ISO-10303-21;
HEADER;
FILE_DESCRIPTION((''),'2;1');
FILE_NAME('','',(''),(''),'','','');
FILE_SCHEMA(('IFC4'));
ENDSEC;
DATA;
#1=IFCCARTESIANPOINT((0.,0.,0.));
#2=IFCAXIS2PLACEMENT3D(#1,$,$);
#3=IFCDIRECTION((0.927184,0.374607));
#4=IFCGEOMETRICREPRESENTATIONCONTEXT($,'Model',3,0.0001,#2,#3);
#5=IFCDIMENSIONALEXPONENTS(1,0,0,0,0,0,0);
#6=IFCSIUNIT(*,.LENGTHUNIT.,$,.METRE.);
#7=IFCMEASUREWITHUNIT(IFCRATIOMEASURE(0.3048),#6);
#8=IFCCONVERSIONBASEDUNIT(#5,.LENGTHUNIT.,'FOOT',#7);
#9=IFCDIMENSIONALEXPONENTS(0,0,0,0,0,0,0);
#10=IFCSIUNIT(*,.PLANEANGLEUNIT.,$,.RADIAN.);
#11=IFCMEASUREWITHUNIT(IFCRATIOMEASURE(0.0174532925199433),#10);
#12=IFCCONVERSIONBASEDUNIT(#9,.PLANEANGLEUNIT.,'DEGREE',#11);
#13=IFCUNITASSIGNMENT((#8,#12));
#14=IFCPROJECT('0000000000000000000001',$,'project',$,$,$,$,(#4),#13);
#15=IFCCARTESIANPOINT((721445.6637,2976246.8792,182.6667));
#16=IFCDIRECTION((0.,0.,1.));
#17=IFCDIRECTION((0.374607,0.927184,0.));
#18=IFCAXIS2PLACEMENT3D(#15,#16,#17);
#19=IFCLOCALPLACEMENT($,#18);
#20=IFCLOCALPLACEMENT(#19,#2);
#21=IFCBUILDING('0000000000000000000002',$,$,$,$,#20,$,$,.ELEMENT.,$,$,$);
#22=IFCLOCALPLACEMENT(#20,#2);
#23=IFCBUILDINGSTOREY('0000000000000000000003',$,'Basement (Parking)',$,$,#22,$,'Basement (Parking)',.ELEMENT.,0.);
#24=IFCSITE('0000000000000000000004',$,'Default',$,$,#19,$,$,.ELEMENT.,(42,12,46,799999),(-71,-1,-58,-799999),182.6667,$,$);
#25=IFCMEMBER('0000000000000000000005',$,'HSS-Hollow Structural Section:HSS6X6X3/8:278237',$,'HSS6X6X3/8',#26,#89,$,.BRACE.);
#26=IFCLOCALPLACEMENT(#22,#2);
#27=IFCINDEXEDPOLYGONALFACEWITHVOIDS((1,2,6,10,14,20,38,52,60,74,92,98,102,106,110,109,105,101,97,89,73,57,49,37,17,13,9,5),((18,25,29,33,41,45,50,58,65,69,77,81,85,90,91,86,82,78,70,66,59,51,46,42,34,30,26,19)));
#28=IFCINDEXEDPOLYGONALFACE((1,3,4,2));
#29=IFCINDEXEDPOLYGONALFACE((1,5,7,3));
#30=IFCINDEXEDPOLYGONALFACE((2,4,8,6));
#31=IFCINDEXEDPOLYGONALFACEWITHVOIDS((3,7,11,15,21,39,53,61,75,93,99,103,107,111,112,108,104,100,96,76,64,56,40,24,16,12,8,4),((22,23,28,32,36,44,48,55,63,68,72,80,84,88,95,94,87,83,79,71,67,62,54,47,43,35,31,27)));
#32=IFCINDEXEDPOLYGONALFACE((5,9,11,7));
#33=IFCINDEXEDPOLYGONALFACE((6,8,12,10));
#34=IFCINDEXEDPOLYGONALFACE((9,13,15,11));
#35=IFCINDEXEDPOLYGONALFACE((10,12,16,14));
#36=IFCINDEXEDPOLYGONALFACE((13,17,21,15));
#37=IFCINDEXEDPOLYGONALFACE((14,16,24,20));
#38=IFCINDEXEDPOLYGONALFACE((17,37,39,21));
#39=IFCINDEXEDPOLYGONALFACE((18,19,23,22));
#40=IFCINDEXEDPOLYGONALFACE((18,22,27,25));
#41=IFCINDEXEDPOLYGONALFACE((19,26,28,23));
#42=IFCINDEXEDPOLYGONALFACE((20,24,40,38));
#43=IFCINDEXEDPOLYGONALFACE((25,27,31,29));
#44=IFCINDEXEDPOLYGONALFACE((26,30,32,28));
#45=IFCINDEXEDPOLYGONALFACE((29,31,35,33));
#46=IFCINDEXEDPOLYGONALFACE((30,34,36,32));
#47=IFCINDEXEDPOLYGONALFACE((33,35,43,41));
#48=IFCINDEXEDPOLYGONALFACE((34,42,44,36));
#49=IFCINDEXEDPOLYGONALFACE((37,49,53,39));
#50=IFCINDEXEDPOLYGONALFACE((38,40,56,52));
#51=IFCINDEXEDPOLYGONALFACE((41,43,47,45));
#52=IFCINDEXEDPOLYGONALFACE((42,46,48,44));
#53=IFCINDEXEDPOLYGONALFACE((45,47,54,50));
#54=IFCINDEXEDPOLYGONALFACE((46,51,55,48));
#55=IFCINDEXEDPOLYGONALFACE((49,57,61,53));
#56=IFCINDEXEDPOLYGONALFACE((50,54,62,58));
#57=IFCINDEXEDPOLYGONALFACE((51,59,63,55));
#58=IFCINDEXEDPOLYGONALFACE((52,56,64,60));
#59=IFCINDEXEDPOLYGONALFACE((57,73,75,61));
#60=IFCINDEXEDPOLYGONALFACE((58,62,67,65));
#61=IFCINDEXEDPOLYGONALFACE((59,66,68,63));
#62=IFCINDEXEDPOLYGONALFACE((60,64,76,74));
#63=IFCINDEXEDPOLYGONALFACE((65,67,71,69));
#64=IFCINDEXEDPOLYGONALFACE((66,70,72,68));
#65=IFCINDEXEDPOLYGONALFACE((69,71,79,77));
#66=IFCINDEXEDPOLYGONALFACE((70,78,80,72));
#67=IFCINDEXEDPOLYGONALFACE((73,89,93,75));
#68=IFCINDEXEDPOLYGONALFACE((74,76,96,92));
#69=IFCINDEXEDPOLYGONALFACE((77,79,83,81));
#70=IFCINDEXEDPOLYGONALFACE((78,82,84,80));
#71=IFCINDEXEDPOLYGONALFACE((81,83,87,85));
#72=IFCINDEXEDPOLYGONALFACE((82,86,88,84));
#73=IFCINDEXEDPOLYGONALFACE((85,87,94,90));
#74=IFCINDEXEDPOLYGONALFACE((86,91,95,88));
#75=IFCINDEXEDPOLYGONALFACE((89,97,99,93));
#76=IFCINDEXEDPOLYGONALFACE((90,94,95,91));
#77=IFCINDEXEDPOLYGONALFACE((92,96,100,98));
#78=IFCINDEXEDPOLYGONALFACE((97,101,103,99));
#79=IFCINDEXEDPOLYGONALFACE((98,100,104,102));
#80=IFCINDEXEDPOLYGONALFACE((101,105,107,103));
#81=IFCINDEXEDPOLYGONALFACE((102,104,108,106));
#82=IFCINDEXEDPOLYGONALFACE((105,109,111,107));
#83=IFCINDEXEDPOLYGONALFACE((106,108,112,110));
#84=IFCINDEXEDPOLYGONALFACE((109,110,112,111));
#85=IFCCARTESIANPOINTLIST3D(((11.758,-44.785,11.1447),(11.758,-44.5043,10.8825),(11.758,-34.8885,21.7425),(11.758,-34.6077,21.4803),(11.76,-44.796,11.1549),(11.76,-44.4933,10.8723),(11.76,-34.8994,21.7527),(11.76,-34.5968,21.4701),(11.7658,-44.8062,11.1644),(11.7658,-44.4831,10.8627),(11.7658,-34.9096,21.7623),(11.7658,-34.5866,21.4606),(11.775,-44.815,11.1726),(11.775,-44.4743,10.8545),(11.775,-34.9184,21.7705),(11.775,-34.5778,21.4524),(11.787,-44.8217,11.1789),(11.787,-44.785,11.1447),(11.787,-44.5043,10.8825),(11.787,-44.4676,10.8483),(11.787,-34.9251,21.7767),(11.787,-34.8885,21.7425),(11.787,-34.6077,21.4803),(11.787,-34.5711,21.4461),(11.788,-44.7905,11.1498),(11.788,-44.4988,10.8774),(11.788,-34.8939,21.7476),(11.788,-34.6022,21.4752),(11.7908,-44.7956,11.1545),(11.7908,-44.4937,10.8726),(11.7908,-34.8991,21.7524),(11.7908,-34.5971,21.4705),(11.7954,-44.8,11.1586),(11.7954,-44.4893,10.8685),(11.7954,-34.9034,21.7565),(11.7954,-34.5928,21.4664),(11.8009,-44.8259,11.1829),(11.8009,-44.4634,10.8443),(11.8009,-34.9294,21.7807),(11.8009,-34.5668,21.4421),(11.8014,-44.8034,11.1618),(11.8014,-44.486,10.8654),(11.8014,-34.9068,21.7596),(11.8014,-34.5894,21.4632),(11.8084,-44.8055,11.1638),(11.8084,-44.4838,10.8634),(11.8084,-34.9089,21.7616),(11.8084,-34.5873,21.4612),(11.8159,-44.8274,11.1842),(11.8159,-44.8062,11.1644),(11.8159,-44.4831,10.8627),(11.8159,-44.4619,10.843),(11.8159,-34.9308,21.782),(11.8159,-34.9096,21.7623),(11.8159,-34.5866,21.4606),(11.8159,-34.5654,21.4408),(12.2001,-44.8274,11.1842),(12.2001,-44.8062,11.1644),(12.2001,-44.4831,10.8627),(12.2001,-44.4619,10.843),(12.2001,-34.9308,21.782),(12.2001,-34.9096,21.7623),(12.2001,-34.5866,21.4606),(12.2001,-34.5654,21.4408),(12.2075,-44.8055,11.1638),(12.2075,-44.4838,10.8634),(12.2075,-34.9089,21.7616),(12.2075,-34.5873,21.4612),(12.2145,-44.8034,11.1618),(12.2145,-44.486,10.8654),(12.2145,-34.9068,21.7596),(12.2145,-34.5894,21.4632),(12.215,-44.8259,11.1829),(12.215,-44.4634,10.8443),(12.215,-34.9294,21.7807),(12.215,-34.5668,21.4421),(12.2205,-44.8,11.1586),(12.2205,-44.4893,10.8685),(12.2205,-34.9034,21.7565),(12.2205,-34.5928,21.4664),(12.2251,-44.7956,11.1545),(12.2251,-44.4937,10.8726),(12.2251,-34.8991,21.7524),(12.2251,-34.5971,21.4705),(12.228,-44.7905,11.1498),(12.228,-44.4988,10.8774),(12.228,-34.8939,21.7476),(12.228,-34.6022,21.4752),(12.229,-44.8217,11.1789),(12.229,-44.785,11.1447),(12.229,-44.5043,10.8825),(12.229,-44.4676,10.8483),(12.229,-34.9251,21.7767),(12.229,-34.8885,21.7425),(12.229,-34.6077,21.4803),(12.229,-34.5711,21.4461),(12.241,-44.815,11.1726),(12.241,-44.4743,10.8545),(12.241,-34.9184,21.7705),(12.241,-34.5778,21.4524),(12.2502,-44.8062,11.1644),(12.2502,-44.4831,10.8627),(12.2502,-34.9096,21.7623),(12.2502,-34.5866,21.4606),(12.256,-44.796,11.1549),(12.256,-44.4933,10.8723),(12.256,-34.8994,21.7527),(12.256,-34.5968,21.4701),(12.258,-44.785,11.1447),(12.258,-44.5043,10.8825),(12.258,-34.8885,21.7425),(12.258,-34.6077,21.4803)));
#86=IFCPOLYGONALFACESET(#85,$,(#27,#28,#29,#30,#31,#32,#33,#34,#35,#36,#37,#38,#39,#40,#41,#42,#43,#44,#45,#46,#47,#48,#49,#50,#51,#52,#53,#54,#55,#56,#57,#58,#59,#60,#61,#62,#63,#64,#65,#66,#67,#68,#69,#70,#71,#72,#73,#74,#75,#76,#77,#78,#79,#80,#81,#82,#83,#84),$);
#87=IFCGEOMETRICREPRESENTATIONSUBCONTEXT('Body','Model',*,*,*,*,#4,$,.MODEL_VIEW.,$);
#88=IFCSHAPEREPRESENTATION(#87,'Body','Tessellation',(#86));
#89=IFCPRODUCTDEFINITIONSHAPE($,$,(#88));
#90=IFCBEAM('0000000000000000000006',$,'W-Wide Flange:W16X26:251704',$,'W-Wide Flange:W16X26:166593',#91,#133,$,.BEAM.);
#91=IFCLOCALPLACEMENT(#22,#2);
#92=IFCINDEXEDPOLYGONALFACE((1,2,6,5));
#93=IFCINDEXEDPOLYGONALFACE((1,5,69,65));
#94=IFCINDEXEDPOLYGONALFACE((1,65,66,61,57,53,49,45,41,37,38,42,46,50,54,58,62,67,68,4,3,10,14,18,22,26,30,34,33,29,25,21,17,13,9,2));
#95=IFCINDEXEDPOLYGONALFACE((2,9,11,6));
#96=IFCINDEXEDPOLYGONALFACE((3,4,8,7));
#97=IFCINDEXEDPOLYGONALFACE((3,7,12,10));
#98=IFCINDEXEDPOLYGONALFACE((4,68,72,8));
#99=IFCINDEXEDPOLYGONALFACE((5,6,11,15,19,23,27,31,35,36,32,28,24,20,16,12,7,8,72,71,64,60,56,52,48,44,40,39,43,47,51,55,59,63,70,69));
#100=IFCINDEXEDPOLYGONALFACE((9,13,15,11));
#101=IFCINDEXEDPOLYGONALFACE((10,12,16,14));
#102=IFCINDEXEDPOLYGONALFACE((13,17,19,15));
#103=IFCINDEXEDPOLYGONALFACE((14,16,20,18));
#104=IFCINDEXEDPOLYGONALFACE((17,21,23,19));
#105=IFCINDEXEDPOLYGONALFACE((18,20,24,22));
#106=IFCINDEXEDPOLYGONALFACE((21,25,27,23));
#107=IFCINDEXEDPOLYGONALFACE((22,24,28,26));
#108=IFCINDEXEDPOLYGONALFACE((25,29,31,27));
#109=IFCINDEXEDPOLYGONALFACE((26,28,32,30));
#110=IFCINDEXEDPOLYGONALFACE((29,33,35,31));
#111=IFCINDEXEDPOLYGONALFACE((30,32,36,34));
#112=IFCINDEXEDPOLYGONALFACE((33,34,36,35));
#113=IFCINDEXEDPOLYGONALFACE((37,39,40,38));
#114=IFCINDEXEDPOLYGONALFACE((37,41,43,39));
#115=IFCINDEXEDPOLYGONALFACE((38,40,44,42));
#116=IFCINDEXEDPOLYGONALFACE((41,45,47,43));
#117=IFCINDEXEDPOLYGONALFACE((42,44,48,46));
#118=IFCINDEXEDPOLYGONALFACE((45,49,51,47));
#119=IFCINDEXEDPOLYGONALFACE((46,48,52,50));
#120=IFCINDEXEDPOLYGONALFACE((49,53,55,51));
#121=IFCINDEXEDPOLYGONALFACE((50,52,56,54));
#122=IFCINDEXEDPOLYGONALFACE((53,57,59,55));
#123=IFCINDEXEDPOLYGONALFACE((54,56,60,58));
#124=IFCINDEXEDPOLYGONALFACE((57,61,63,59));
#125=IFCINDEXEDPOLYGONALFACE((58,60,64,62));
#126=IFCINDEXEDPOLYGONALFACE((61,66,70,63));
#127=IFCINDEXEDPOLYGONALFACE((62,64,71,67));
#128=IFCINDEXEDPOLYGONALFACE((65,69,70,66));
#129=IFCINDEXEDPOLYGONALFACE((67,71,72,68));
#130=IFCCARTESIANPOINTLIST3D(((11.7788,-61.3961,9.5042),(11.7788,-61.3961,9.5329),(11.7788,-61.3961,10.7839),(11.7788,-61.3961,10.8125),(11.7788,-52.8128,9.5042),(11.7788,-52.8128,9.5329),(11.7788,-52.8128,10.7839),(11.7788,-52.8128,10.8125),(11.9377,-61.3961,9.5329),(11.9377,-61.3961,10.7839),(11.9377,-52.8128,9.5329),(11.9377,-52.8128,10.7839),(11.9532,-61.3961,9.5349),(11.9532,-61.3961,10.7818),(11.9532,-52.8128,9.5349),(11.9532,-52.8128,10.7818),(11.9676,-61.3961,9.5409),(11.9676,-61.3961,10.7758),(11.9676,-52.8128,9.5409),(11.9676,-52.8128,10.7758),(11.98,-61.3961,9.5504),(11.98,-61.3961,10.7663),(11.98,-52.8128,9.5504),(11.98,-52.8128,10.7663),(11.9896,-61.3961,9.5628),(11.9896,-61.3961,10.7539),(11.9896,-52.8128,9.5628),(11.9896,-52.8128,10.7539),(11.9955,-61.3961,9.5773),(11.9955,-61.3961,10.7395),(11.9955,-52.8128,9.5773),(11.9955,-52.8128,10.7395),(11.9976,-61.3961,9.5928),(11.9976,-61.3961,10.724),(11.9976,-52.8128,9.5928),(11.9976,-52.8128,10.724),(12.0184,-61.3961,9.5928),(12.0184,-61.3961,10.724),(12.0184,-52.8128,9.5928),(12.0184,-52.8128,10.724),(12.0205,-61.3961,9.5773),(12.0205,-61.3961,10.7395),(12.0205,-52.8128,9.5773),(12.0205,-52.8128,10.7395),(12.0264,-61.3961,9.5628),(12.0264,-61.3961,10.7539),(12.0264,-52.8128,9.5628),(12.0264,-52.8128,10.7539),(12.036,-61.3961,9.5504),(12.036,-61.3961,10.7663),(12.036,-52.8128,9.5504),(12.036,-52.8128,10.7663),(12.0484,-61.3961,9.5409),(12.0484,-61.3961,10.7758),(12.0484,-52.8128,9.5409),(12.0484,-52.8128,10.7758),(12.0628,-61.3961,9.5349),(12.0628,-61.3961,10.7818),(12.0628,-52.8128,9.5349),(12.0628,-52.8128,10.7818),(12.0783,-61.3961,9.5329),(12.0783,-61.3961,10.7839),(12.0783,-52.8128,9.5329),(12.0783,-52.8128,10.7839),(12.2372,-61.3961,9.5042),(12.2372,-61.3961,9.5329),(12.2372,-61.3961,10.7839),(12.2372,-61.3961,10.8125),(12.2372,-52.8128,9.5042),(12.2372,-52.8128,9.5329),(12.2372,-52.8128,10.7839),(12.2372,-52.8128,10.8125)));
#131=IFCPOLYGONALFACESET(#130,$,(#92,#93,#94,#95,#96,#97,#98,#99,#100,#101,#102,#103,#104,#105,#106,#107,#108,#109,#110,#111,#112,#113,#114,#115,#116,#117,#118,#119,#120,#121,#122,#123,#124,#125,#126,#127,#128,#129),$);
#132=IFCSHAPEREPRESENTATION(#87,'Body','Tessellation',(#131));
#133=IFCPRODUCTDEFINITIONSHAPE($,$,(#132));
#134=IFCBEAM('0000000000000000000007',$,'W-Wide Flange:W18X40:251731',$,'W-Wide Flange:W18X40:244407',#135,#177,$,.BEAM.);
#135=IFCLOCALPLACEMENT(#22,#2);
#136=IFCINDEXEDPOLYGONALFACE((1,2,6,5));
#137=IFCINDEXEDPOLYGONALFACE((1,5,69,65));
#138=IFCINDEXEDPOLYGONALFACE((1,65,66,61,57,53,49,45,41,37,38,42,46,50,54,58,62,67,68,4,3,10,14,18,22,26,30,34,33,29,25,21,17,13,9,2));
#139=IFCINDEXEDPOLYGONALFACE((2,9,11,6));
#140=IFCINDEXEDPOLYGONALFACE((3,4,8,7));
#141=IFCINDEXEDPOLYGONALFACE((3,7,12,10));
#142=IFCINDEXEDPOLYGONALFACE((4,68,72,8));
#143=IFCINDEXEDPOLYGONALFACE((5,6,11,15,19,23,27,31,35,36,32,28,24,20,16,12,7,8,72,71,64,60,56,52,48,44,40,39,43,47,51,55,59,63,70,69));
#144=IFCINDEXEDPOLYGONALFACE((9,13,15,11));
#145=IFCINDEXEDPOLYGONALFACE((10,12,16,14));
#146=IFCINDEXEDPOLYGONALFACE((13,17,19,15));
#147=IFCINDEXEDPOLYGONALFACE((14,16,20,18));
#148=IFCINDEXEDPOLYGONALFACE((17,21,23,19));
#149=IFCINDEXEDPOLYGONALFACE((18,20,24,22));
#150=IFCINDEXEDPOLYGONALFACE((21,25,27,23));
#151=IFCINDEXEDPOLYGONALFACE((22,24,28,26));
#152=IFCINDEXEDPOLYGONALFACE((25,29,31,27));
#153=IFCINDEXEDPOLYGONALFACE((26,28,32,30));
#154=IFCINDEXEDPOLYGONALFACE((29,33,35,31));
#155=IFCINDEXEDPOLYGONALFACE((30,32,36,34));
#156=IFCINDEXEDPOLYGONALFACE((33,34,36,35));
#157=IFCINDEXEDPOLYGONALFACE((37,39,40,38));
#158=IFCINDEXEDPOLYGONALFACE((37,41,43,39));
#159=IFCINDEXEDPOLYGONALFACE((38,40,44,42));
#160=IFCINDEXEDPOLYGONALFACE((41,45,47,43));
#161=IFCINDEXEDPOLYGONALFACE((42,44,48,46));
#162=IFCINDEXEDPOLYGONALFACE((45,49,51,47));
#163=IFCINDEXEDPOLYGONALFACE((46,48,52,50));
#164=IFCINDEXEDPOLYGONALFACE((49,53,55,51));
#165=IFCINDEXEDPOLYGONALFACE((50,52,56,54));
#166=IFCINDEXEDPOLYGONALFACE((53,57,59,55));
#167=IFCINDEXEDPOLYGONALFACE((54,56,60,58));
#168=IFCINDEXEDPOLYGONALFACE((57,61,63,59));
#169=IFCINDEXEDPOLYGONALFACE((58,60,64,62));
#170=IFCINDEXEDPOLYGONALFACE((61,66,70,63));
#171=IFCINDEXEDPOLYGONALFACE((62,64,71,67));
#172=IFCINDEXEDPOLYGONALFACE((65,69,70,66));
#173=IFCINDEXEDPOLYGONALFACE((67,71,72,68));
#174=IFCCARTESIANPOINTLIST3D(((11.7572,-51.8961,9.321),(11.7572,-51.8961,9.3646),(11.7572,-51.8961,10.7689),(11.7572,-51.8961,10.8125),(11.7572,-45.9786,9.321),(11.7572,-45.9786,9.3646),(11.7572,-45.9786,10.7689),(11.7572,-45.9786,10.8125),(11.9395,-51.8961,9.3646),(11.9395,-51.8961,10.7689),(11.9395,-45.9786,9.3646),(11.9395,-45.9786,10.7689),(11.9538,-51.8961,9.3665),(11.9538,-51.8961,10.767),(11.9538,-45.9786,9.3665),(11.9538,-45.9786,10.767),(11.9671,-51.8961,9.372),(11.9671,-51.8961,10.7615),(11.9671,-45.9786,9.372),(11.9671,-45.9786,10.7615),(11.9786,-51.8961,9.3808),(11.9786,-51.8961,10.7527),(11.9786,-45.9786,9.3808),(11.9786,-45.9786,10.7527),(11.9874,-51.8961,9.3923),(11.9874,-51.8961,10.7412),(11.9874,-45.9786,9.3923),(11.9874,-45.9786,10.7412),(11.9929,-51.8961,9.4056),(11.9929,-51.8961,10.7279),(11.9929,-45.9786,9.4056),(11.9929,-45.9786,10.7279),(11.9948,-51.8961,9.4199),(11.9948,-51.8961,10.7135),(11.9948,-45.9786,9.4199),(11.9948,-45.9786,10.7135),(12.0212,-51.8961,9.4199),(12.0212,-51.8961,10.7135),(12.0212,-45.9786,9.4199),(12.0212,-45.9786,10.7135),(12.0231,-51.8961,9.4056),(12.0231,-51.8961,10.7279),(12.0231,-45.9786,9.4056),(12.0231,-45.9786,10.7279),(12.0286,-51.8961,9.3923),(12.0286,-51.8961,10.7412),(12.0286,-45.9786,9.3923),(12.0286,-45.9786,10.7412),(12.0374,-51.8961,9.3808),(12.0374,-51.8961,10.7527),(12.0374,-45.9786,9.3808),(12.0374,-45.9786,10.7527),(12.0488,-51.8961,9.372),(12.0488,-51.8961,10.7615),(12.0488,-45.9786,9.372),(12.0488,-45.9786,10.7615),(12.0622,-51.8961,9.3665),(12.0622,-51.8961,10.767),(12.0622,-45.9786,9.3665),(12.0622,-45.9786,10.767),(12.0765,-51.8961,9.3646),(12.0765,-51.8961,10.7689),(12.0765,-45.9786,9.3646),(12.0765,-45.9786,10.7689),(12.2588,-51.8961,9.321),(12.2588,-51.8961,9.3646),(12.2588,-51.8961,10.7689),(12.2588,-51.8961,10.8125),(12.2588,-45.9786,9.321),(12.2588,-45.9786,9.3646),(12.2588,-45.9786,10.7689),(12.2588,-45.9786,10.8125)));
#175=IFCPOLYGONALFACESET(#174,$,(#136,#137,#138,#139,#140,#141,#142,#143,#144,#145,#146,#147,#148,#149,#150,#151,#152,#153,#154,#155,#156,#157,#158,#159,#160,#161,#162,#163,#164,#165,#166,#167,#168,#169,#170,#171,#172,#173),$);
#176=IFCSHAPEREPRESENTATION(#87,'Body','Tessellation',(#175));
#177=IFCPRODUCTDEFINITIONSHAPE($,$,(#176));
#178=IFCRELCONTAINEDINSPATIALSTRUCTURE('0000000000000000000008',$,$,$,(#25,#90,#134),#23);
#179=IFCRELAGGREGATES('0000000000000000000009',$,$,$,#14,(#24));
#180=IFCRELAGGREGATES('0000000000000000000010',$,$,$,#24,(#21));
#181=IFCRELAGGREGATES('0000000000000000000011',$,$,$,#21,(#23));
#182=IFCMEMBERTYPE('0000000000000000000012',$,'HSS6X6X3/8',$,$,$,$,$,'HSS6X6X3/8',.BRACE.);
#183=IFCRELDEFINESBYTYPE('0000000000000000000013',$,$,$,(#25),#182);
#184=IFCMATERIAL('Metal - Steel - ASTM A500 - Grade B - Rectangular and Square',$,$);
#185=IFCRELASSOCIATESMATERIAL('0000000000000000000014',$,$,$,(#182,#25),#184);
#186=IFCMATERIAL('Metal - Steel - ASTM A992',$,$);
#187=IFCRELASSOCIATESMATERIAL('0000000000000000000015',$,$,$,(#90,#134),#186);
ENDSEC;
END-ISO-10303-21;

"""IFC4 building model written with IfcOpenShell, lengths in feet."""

from ifc_helpers import new_model, entity, si_unit, converted_unit, direction, frame, frame_2d, origin, place, context, subcontext, project, spatial, polyline, circle_curve, parameter, trimmed, segment, composite_curve, i_section, outline, extrude, source, transform, mapped, material, type_object, type_shapes, element, save


model = new_model("IFC4")

# Units and contexts
model_context = context("Model", 3, precision=0.0001, world=origin(), true_north=direction((0.927184, 0.374607)))
body_context = subcontext(model_context, "Body", "Model", "MODEL_VIEW")
ifc_project = project(units=[converted_unit("LENGTHUNIT", "FOOT", entity("IfcRatioMeasure", 0.3048), si_unit("LENGTHUNIT", "METRE"), dimensions=[1, 0, 0, 0, 0, 0, 0]), converted_unit("PLANEANGLEUNIT", "DEGREE", entity("IfcRatioMeasure", 0.0174532925199433), si_unit("PLANEANGLEUNIT", "RADIAN"), dimensions=[0, 0, 0, 0, 0, 0, 0])], contexts=[model_context])

# Site, building, storey
site_placement = place(None, frame((721445.6637, 2976246.8792, 182.6667), z_axis=(0.0, 0.0, 1.0), x_axis=(0.374607, 0.927184, 0.0)))
site = spatial("IfcSite", under=ifc_project, at=site_placement, Name="Default", CompositionType="ELEMENT", RefLatitude=(42, 12, 46, 799999), RefLongitude=(-71, -1, -58, -799999), RefElevation=182.6667)
building_placement = place(site_placement, origin())
building = spatial("IfcBuilding", under=site, at=building_placement, CompositionType="ELEMENT")
storey_placement = place(building_placement, origin())
storey = spatial("IfcBuildingStorey", under=building, at=storey_placement, Name="Basement (Parking)", LongName="Basement (Parking)", CompositionType="ELEMENT", Elevation=0.0)

# Shared definitions
ifc_material_1 = material(Name="Metal - Steel - ASTM A992")

# Member
ifc_material_2 = material(Name="Metal - Steel - ASTM A500 - Grade B - Rectangular and Square")
member_type = type_object("IfcMemberType", Name="HSS6X6X3/8", ElementType="HSS6X6X3/8", PredefinedType="BRACE", material=ifc_material_2)
shared_shape_1 = source(origin(), body_context, "Body", "SweptSolid", [
    extrude(outline(composite_curve([segment(trimmed(circle_curve(frame_2d((-0.1921, -0.1921), x_axis=(1.0, 0.0)), 0.0579), [parameter(180.0)], [parameter(270.0)], True, "PARAMETER"), True, "CONTINUOUS"), segment(polyline([(-0.1921, -0.25), (0.1921, -0.25)]), True, "CONTINUOUS"), segment(trimmed(circle_curve(frame_2d((0.1921, -0.1921), x_axis=(1.0, 0.0)), 0.0579), [parameter(270.0)], [parameter(0.0)], True, "PARAMETER"), True, "CONTINUOUS"), segment(polyline([(0.25, -0.1921), (0.25, 0.1921)]), True, "CONTINUOUS"), segment(trimmed(circle_curve(frame_2d((0.1921, 0.1921), x_axis=(1.0, 0.0)), 0.0579), [parameter(360.0)], [parameter(90.0)], True, "PARAMETER"), True, "CONTINUOUS"), segment(polyline([(0.1921, 0.25), (-0.1921, 0.25)]), True, "CONTINUOUS"), segment(trimmed(circle_curve(frame_2d((-0.1921, 0.1921), x_axis=(1.0, 0.0)), 0.0579), [parameter(90.0)], [parameter(180.0)], True, "PARAMETER"), True, "CONTINUOUS"), segment(polyline([(-0.25, 0.1921), (-0.25, -0.1921)]), True, "CONTINUOUS")], self_intersect=False), holes=[composite_curve([segment(polyline([(0.1921, -0.221), (-0.1921, -0.221)]), True, "CONTINUOUS"), segment(trimmed(circle_curve(frame_2d((-0.1921, -0.1921), x_axis=(1.0, 0.0)), 0.029), [parameter(180.0)], [parameter(270.0)], True, "PARAMETER"), False, "CONTINUOUS"), segment(polyline([(-0.221, -0.1921), (-0.221, 0.1921)]), True, "CONTINUOUS"), segment(trimmed(circle_curve(frame_2d((-0.1921, 0.1921), x_axis=(1.0, 0.0)), 0.029), [parameter(90.0)], [parameter(180.0)], True, "PARAMETER"), False, "CONTINUOUS"), segment(polyline([(-0.1921, 0.221), (0.1921, 0.221)]), True, "CONTINUOUS"), segment(trimmed(circle_curve(frame_2d((0.1921, 0.1921), x_axis=(1.0, 0.0)), 0.029), [parameter(0.0)], [parameter(90.0)], True, "PARAMETER"), False, "CONTINUOUS"), segment(polyline([(0.221, 0.1921), (0.221, -0.1921)]), True, "CONTINUOUS"), segment(trimmed(circle_curve(frame_2d((0.1921, -0.1921), x_axis=(1.0, 0.0)), 0.029), [parameter(270.0)], [parameter(0.0)], True, "PARAMETER"), False, "CONTINUOUS")], self_intersect=False)]), frame((-7.2017, 0.0, 0.0), z_axis=(1.0, 0.0, 0.0), x_axis=(0.0, -1.0, 0.0)), (0.0, 0.0, 1.0), 14.5002),
])
type_shapes(member_type, [shared_shape_1])
member_placement = place(storey_placement, frame((12.008, -39.7294, 16.2771), z_axis=(0.0, -0.730875, 0.682512), x_axis=(0.0, 0.682512, 0.730875)))
element("IfcMember", 1, at=member_placement, inside=storey, type_object=member_type, material=ifc_material_2, Name="HSS-Hollow Structural Section:HSS6X6X3/8:278237", ObjectType="HSS6X6X3/8", PredefinedType="BRACE", context=body_context, shape_type="MappedRepresentation", body=[
    mapped(shared_shape_1, transform((0.0, 0.0, 0.0), scale=1.0)),
])

# Beams
beam_1_placement = place(storey_placement, frame((12.008, -61.3961, 10.8125), z_axis=(0.0, 0.0, 1.0), x_axis=(0.0, 1.0, 0.0)))
element("IfcBeam", 2, at=beam_1_placement, inside=storey, material=ifc_material_1, Name="W-Wide Flange:W16X26:251704", ObjectType="W-Wide Flange:W16X26:166593", PredefinedType="BEAM", context=body_context, shape_type="SweptSolid", body=[
    extrude(i_section(OverallWidth=0.4583, OverallDepth=1.3083, WebThickness=0.0208, FlangeThickness=0.0286, FilletRadius=0.0599, at=frame_2d((0.0, 0.0), x_axis=(0.0, 1.0))), frame((0.0, 0.0, -0.6541), z_axis=(1.0, 0.0, 0.0), x_axis=(0.0, 0.0, -1.0)), (0.0, 0.0, 1.0), 8.5833),
])
beam_2_placement = place(storey_placement, frame((12.008, -52.3544, 10.8125), z_axis=(0.0, 0.0, 1.0), x_axis=(0.0, 1.0, 0.0)))
element("IfcBeam", 3, at=beam_2_placement, inside=storey, material=ifc_material_1, Name="W-Wide Flange:W18X40:251731", ObjectType="W-Wide Flange:W18X40:244407", PredefinedType="BEAM", context=body_context, shape_type="SweptSolid", body=[
    extrude(i_section(OverallWidth=0.5016, OverallDepth=1.4915, WebThickness=0.0264, FlangeThickness=0.0436, FilletRadius=0.0553, at=frame_2d((0.0, 0.0), x_axis=(0.0, 1.0))), frame((0.4583, 0.0, -0.7458), z_axis=(1.0, 0.0, 0.0), x_axis=(0.0, 0.0, -1.0)), (0.0, 0.0, 1.0), 5.9175),
])

save(model, "model.ifc")
